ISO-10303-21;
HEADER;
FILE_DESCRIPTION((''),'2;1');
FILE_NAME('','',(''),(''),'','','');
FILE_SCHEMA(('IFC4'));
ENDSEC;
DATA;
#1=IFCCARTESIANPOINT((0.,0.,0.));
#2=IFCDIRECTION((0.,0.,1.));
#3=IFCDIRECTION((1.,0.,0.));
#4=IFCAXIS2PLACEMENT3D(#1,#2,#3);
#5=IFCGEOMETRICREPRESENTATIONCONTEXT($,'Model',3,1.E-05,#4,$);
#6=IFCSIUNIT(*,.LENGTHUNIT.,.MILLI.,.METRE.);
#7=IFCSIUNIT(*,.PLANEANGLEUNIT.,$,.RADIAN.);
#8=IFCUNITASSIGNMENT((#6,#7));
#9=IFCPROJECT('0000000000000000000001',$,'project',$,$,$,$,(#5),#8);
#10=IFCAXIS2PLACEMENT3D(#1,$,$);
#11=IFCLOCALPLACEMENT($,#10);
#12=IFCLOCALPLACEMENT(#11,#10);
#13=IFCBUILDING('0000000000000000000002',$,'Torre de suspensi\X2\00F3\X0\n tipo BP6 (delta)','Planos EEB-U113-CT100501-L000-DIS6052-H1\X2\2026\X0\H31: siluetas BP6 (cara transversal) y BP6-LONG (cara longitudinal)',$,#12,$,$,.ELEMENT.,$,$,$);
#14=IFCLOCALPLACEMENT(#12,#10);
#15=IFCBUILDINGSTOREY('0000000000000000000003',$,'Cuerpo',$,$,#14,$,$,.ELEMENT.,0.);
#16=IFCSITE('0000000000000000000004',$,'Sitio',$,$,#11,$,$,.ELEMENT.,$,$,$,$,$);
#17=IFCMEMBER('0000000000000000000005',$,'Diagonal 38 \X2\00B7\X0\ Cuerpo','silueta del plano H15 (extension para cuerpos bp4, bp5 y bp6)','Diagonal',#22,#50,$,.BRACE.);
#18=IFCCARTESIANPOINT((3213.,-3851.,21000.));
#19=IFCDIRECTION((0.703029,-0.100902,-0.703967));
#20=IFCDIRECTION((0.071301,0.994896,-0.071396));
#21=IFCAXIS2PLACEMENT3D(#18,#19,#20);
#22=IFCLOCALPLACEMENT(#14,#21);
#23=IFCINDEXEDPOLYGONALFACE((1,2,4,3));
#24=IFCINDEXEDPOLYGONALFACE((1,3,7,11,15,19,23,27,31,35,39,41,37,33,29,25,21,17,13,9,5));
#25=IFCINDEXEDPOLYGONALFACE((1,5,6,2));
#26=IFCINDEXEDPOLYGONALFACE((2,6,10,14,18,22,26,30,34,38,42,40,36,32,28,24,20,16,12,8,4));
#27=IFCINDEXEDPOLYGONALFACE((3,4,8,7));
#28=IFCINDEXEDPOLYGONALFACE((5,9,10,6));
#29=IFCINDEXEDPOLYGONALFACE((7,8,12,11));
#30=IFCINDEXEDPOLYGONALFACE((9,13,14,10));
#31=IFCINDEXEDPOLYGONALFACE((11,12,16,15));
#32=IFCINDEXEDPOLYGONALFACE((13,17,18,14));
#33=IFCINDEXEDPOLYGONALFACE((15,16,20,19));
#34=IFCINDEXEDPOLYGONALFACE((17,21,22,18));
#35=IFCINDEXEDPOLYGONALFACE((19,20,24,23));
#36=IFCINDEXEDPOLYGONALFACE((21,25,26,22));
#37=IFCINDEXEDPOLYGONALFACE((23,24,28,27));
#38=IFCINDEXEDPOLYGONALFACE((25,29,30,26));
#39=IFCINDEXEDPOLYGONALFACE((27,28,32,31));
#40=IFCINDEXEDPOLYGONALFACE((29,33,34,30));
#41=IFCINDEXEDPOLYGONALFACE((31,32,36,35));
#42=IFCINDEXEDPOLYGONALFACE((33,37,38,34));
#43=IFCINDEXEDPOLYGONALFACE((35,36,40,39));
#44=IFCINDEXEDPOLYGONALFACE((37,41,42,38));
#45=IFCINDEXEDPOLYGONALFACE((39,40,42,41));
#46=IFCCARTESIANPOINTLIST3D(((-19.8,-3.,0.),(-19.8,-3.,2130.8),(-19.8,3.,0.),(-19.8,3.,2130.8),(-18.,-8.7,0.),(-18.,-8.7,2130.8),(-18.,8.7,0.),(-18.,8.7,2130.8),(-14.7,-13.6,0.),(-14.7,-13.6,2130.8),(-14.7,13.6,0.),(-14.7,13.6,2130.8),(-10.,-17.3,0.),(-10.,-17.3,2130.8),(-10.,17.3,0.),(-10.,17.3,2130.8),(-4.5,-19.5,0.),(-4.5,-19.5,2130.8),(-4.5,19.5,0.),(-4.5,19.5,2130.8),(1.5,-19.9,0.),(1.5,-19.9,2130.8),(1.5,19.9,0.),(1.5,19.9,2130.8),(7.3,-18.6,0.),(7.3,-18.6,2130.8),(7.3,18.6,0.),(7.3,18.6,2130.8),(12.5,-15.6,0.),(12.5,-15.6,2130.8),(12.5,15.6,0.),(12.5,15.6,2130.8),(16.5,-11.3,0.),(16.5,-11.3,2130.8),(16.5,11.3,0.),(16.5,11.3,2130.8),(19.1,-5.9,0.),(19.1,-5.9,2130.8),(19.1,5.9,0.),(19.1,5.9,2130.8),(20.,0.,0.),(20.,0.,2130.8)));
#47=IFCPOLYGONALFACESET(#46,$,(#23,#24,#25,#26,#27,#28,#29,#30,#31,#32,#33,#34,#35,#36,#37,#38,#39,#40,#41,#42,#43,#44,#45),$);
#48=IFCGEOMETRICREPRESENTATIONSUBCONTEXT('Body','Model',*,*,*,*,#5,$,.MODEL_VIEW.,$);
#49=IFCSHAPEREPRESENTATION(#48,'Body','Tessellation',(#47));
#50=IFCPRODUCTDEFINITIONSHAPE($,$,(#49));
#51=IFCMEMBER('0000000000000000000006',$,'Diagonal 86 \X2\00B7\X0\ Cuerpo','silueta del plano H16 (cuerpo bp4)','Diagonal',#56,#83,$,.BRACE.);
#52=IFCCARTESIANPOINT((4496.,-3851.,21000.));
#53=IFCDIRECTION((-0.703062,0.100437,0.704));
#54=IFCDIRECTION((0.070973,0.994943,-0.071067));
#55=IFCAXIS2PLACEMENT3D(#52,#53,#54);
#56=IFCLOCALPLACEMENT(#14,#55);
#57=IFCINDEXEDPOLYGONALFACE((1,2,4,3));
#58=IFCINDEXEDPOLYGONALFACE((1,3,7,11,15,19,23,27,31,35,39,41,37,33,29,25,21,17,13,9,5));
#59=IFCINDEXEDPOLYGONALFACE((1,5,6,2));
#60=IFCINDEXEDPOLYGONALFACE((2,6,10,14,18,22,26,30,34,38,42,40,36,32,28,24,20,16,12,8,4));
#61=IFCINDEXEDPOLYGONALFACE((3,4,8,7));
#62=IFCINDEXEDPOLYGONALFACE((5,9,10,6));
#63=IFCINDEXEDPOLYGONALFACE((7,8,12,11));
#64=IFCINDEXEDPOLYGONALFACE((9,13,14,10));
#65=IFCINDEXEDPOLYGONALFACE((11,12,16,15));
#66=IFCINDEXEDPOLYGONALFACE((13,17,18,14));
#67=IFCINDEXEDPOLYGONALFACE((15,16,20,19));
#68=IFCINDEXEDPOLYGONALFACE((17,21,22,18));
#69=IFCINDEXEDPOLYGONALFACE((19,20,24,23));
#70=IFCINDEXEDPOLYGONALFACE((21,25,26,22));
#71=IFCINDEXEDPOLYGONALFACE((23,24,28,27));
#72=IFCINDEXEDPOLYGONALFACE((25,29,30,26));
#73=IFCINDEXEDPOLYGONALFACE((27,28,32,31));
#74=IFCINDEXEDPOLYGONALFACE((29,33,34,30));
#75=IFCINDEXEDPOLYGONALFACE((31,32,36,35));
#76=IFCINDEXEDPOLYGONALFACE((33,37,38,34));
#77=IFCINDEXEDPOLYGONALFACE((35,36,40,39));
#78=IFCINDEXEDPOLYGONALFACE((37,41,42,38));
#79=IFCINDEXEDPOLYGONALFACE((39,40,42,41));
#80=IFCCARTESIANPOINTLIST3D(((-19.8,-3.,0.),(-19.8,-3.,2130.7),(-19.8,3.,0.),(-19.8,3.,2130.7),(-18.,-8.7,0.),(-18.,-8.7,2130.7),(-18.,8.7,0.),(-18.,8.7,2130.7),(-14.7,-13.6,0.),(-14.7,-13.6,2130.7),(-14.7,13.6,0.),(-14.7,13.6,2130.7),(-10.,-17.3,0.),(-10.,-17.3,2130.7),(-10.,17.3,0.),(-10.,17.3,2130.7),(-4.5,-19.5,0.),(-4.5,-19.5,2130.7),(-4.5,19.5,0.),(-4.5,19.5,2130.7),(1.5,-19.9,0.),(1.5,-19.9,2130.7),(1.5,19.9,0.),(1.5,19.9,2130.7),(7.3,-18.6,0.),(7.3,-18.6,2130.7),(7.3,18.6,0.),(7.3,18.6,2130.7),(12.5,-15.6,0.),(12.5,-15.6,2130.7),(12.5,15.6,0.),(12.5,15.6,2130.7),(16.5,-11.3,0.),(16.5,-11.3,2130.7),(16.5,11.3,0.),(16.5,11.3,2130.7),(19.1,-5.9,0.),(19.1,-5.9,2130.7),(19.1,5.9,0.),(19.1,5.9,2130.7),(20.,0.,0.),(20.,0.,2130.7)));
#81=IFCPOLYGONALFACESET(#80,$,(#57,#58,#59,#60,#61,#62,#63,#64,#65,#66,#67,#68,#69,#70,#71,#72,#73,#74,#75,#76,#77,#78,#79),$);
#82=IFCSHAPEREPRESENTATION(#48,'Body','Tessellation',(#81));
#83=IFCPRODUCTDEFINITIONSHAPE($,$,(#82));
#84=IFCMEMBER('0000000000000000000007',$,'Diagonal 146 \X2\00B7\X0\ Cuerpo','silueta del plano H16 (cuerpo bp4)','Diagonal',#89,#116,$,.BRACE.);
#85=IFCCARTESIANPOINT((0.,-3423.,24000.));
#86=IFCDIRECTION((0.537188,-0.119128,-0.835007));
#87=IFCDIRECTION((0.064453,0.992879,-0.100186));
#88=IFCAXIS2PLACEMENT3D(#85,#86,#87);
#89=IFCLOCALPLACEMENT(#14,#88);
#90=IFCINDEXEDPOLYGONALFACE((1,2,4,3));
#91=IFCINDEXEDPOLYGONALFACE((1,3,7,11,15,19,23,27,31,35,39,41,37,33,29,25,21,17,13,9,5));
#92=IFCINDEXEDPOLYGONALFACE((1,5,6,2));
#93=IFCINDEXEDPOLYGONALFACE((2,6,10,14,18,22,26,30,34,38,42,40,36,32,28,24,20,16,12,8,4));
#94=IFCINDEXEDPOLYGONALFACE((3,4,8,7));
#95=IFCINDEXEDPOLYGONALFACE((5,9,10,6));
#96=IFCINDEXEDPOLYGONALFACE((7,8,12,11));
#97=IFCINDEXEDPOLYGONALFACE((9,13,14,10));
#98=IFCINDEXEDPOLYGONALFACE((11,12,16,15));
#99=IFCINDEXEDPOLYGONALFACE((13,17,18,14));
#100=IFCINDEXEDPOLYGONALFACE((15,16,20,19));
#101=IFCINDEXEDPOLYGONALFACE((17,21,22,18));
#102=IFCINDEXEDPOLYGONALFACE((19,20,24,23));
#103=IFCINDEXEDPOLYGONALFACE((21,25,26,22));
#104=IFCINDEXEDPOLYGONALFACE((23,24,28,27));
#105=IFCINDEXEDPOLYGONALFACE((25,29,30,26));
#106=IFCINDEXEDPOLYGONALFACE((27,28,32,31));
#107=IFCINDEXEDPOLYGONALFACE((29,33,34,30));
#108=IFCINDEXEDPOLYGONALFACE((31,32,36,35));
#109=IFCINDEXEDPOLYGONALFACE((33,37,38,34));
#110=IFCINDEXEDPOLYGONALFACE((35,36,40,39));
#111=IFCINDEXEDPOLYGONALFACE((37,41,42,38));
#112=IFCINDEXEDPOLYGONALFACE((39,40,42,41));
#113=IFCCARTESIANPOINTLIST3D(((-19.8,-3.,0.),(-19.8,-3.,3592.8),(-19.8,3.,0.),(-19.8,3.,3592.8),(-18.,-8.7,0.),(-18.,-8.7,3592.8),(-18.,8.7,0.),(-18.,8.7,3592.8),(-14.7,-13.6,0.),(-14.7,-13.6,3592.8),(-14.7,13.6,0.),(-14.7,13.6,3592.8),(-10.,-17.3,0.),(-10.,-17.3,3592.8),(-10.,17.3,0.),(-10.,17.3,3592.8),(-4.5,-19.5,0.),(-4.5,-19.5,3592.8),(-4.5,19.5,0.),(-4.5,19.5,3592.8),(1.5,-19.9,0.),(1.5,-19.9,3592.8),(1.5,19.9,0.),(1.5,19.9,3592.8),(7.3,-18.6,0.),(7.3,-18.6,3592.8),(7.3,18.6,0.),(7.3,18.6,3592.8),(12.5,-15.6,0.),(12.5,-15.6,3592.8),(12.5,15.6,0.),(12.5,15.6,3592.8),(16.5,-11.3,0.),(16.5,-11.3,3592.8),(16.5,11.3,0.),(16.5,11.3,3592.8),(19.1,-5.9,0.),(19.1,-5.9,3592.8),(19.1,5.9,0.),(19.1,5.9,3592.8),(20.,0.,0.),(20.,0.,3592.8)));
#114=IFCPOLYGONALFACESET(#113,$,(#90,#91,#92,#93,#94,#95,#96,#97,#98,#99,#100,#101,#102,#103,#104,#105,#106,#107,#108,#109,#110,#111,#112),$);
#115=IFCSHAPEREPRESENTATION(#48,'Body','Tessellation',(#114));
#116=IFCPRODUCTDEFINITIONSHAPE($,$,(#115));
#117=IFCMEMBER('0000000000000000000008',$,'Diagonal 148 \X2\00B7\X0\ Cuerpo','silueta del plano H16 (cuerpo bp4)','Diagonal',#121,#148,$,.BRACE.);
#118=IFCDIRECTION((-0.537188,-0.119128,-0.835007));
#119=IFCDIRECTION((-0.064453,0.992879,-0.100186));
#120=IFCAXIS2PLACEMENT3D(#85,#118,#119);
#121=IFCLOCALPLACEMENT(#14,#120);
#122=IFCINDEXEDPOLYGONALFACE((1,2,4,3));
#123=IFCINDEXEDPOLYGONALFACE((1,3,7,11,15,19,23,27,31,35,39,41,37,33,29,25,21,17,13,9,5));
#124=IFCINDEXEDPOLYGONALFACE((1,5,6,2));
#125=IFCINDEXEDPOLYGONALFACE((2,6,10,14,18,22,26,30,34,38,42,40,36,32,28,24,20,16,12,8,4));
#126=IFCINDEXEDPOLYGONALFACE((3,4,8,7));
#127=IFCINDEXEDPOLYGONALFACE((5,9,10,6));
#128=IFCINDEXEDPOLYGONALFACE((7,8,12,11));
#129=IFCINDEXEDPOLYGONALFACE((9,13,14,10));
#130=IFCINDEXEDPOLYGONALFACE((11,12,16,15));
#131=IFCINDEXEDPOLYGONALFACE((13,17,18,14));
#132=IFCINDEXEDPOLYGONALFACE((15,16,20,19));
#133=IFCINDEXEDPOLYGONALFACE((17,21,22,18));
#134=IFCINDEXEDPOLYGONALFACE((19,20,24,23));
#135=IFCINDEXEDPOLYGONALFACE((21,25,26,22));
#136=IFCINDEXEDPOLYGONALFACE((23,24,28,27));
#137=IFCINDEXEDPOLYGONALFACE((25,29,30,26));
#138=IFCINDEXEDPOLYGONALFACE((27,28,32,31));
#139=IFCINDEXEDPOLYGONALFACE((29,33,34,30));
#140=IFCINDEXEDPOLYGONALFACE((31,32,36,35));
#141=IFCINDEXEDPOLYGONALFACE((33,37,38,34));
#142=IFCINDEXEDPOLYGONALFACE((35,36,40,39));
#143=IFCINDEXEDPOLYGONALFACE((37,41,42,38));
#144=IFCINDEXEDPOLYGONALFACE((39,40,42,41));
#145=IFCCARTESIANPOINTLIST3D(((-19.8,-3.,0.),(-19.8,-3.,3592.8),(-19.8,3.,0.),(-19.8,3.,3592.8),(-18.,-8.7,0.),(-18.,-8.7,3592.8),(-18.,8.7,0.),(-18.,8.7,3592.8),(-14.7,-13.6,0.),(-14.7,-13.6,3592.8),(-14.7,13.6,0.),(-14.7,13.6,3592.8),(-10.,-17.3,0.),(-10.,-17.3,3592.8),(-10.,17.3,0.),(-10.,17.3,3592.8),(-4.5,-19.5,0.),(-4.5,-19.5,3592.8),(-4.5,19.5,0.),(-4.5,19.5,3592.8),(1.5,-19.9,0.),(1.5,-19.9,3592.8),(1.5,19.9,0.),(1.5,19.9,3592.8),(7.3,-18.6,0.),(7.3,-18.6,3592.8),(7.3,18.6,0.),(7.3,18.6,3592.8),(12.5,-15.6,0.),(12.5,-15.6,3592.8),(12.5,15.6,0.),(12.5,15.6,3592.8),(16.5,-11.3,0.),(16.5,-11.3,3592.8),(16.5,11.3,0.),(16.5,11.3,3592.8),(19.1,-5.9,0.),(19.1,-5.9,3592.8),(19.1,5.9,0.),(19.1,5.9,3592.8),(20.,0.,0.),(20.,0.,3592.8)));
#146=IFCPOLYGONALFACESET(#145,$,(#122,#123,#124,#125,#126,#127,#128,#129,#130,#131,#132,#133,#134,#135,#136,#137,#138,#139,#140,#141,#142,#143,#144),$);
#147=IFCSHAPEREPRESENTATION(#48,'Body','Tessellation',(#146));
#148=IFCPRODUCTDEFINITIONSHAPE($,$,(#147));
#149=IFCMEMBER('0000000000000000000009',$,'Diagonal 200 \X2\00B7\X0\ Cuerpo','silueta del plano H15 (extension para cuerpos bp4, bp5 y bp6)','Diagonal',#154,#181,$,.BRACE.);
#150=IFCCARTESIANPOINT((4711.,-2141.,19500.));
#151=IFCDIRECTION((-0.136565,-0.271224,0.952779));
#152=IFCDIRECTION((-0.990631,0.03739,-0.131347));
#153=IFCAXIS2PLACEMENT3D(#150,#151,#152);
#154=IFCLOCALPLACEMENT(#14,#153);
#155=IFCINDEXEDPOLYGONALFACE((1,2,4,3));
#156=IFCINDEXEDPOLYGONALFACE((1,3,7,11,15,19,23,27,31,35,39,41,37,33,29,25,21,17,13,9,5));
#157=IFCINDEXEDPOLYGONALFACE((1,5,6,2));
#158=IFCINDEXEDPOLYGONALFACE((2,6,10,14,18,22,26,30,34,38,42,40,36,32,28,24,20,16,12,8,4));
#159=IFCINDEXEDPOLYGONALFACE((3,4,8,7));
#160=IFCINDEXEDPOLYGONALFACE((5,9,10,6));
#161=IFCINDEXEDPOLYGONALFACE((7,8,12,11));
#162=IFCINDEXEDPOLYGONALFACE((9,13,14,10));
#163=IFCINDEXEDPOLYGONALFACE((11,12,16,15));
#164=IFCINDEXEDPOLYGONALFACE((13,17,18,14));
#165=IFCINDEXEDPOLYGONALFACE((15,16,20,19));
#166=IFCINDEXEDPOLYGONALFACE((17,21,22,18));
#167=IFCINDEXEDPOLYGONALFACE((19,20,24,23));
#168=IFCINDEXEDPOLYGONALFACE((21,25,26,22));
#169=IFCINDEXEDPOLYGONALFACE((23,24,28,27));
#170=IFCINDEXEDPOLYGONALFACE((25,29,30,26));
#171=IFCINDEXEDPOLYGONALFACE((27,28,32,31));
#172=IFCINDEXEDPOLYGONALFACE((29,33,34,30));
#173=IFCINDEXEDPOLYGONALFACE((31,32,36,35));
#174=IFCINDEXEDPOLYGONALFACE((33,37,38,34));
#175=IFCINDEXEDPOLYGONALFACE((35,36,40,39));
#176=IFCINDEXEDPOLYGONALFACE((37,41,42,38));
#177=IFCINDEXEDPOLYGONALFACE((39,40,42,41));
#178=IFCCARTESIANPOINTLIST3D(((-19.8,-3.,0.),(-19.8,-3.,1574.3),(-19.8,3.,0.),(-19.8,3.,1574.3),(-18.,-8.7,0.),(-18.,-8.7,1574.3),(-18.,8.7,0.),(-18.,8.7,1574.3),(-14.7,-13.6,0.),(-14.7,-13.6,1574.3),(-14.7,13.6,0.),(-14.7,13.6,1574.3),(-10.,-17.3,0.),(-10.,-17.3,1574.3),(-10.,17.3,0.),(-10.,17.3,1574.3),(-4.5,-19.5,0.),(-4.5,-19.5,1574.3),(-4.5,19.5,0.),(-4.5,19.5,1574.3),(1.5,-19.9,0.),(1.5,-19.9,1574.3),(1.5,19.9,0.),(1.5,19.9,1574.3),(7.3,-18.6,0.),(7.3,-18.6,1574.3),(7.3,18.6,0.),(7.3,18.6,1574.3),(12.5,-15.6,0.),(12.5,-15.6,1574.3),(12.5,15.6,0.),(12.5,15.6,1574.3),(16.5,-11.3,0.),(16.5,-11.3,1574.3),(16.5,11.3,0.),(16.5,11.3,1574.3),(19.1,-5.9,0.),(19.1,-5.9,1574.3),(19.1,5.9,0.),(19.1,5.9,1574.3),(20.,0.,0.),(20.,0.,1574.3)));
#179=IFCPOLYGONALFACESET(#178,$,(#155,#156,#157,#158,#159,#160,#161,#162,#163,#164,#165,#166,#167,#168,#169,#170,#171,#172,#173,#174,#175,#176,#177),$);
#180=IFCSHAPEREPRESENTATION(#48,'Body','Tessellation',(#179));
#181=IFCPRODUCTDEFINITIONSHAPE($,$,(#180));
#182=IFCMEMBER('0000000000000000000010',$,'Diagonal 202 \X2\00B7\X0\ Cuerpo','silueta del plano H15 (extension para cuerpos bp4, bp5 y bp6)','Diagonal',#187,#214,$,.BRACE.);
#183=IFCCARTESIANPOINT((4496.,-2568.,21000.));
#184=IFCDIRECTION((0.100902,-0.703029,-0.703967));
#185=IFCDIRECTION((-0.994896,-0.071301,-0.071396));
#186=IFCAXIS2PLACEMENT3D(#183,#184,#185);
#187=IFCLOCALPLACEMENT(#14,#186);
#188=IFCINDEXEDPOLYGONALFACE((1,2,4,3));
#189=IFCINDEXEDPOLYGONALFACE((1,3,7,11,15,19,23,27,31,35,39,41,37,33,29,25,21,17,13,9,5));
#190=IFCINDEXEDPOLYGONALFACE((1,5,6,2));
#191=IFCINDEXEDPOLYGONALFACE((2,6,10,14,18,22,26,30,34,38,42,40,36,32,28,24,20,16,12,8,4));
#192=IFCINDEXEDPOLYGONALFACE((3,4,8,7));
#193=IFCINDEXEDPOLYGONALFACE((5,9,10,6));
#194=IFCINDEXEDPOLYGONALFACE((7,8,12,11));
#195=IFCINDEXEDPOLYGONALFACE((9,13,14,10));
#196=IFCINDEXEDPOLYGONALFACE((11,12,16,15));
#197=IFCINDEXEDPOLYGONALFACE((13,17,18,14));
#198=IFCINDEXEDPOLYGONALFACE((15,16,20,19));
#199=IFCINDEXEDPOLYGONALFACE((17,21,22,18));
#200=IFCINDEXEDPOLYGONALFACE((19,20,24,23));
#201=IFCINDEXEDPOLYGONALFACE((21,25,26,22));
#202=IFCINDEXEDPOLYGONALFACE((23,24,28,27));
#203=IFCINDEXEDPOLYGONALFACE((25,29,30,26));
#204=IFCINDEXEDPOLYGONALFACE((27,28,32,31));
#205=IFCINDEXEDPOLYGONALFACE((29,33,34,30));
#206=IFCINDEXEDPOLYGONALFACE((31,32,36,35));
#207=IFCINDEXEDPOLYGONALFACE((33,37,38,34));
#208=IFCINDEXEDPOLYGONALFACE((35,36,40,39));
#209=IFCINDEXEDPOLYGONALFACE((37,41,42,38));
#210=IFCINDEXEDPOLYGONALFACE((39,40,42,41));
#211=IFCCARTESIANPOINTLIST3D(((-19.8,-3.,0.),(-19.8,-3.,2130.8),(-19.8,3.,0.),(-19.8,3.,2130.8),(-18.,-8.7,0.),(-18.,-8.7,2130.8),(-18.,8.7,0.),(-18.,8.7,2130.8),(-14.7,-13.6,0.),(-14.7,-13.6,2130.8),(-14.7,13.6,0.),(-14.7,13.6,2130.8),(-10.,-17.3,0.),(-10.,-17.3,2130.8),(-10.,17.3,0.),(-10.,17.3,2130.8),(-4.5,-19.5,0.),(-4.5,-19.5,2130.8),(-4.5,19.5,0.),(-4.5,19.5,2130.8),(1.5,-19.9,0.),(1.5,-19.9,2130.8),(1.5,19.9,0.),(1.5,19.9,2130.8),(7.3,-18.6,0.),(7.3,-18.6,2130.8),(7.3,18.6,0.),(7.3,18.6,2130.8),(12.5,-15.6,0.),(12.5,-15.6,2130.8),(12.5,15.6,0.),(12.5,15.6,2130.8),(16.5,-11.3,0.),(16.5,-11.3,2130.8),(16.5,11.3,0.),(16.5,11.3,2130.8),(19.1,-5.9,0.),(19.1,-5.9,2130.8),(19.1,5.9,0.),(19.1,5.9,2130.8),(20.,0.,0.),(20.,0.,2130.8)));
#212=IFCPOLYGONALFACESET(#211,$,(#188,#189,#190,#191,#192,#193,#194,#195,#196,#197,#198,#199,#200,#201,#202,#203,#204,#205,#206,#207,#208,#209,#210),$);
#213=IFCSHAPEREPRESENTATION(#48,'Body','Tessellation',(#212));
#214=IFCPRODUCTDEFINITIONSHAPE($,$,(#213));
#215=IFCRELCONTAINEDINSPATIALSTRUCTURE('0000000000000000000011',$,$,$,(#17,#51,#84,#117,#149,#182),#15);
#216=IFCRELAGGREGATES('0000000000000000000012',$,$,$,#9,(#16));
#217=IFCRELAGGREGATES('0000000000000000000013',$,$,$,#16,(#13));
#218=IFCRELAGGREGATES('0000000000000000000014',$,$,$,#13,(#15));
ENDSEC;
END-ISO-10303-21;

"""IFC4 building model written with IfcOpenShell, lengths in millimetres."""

from ifc_helpers import new_model, si_unit, frame, origin, origin_with_axes, place, context, subcontext, project, spatial, circle, extrude, element, save


model = new_model("IFC4")

# Units and contexts
model_context = context("Model", 3, precision=1e-05, world=origin_with_axes())
body_context = subcontext(model_context, "Body", "Model", "MODEL_VIEW")
ifc_project = project(units=[si_unit("LENGTHUNIT", "METRE", prefix="MILLI"), si_unit("PLANEANGLEUNIT", "RADIAN")], contexts=[model_context])

# Site, building, storey
site_placement = place(None, origin())
site = spatial("IfcSite", under=ifc_project, at=site_placement, Name="Sitio", CompositionType="ELEMENT")
building_placement = place(site_placement, origin())
building = spatial("IfcBuilding", under=site, at=building_placement, Name="Torre de suspensión tipo BP6 (delta)", Description="Planos EEB-U113-CT100501-L000-DIS6052-H1…H31: siluetas BP6 (cara transversal) y BP6-LONG (cara longitudinal)", CompositionType="ELEMENT")
storey_placement = place(building_placement, origin())
storey = spatial("IfcBuildingStorey", under=building, at=storey_placement, Name="Cuerpo", CompositionType="ELEMENT", Elevation=0.0)

# Members
member_1_placement = place(storey_placement, frame((3213.0, -3851.0, 21000.0), z_axis=(0.703029, -0.100902, -0.703967), x_axis=(0.071301, 0.994896, -0.071396)))
element("IfcMember", 1, at=member_1_placement, inside=storey, Name="Diagonal 38 · Cuerpo", Description="silueta del plano H15 (extension para cuerpos bp4, bp5 y bp6)", ObjectType="Diagonal", PredefinedType="BRACE", context=body_context, shape_type="SweptSolid", body=[
    extrude(circle(Radius=20.0), None, (0.0, 0.0, 1.0), 2130.8),
])
member_2_placement = place(storey_placement, frame((4496.0, -3851.0, 21000.0), z_axis=(-0.703062, 0.100437, 0.704), x_axis=(0.070973, 0.994943, -0.071067)))
element("IfcMember", 2, at=member_2_placement, inside=storey, Name="Diagonal 86 · Cuerpo", Description="silueta del plano H16 (cuerpo bp4)", ObjectType="Diagonal", PredefinedType="BRACE", context=body_context, shape_type="SweptSolid", body=[
    extrude(circle(Radius=20.0), None, (0.0, 0.0, 1.0), 2130.7),
])
for number, where, z_axis, x_axis, name in (
    (3, (0.0, -3423.0, 24000.0), (0.537188, -0.119128, -0.835007), (0.064453, 0.992879, -0.100186), "Diagonal 146 · Cuerpo"),
    (4, (0.0, -3423.0, 24000.0), (-0.537188, -0.119128, -0.835007), (-0.064453, 0.992879, -0.100186), "Diagonal 148 · Cuerpo"),
):
    element("IfcMember", number, at=place(storey_placement, frame(where, z_axis=z_axis, x_axis=x_axis)), inside=storey, Name=name, Description="silueta del plano H16 (cuerpo bp4)", ObjectType="Diagonal", PredefinedType="BRACE", context=body_context, shape_type="SweptSolid", body=[
        extrude(circle(Radius=20.0), None, (0.0, 0.0, 1.0), 3592.8),
    ])
member_3_placement = place(storey_placement, frame((4711.0, -2141.0, 19500.0), z_axis=(-0.136565, -0.271224, 0.952779), x_axis=(-0.990631, 0.03739, -0.131347)))
element("IfcMember", 5, at=member_3_placement, inside=storey, Name="Diagonal 200 · Cuerpo", Description="silueta del plano H15 (extension para cuerpos bp4, bp5 y bp6)", ObjectType="Diagonal", PredefinedType="BRACE", context=body_context, shape_type="SweptSolid", body=[
    extrude(circle(Radius=20.0), None, (0.0, 0.0, 1.0), 1574.3),
])
member_4_placement = place(storey_placement, frame((4496.0, -2568.0, 21000.0), z_axis=(0.100902, -0.703029, -0.703967), x_axis=(-0.994896, -0.071301, -0.071396)))
element("IfcMember", 6, at=member_4_placement, inside=storey, Name="Diagonal 202 · Cuerpo", Description="silueta del plano H15 (extension para cuerpos bp4, bp5 y bp6)", ObjectType="Diagonal", PredefinedType="BRACE", context=body_context, shape_type="SweptSolid", body=[
    extrude(circle(Radius=20.0), None, (0.0, 0.0, 1.0), 2130.8),
])

save(model, "model.ifc")
